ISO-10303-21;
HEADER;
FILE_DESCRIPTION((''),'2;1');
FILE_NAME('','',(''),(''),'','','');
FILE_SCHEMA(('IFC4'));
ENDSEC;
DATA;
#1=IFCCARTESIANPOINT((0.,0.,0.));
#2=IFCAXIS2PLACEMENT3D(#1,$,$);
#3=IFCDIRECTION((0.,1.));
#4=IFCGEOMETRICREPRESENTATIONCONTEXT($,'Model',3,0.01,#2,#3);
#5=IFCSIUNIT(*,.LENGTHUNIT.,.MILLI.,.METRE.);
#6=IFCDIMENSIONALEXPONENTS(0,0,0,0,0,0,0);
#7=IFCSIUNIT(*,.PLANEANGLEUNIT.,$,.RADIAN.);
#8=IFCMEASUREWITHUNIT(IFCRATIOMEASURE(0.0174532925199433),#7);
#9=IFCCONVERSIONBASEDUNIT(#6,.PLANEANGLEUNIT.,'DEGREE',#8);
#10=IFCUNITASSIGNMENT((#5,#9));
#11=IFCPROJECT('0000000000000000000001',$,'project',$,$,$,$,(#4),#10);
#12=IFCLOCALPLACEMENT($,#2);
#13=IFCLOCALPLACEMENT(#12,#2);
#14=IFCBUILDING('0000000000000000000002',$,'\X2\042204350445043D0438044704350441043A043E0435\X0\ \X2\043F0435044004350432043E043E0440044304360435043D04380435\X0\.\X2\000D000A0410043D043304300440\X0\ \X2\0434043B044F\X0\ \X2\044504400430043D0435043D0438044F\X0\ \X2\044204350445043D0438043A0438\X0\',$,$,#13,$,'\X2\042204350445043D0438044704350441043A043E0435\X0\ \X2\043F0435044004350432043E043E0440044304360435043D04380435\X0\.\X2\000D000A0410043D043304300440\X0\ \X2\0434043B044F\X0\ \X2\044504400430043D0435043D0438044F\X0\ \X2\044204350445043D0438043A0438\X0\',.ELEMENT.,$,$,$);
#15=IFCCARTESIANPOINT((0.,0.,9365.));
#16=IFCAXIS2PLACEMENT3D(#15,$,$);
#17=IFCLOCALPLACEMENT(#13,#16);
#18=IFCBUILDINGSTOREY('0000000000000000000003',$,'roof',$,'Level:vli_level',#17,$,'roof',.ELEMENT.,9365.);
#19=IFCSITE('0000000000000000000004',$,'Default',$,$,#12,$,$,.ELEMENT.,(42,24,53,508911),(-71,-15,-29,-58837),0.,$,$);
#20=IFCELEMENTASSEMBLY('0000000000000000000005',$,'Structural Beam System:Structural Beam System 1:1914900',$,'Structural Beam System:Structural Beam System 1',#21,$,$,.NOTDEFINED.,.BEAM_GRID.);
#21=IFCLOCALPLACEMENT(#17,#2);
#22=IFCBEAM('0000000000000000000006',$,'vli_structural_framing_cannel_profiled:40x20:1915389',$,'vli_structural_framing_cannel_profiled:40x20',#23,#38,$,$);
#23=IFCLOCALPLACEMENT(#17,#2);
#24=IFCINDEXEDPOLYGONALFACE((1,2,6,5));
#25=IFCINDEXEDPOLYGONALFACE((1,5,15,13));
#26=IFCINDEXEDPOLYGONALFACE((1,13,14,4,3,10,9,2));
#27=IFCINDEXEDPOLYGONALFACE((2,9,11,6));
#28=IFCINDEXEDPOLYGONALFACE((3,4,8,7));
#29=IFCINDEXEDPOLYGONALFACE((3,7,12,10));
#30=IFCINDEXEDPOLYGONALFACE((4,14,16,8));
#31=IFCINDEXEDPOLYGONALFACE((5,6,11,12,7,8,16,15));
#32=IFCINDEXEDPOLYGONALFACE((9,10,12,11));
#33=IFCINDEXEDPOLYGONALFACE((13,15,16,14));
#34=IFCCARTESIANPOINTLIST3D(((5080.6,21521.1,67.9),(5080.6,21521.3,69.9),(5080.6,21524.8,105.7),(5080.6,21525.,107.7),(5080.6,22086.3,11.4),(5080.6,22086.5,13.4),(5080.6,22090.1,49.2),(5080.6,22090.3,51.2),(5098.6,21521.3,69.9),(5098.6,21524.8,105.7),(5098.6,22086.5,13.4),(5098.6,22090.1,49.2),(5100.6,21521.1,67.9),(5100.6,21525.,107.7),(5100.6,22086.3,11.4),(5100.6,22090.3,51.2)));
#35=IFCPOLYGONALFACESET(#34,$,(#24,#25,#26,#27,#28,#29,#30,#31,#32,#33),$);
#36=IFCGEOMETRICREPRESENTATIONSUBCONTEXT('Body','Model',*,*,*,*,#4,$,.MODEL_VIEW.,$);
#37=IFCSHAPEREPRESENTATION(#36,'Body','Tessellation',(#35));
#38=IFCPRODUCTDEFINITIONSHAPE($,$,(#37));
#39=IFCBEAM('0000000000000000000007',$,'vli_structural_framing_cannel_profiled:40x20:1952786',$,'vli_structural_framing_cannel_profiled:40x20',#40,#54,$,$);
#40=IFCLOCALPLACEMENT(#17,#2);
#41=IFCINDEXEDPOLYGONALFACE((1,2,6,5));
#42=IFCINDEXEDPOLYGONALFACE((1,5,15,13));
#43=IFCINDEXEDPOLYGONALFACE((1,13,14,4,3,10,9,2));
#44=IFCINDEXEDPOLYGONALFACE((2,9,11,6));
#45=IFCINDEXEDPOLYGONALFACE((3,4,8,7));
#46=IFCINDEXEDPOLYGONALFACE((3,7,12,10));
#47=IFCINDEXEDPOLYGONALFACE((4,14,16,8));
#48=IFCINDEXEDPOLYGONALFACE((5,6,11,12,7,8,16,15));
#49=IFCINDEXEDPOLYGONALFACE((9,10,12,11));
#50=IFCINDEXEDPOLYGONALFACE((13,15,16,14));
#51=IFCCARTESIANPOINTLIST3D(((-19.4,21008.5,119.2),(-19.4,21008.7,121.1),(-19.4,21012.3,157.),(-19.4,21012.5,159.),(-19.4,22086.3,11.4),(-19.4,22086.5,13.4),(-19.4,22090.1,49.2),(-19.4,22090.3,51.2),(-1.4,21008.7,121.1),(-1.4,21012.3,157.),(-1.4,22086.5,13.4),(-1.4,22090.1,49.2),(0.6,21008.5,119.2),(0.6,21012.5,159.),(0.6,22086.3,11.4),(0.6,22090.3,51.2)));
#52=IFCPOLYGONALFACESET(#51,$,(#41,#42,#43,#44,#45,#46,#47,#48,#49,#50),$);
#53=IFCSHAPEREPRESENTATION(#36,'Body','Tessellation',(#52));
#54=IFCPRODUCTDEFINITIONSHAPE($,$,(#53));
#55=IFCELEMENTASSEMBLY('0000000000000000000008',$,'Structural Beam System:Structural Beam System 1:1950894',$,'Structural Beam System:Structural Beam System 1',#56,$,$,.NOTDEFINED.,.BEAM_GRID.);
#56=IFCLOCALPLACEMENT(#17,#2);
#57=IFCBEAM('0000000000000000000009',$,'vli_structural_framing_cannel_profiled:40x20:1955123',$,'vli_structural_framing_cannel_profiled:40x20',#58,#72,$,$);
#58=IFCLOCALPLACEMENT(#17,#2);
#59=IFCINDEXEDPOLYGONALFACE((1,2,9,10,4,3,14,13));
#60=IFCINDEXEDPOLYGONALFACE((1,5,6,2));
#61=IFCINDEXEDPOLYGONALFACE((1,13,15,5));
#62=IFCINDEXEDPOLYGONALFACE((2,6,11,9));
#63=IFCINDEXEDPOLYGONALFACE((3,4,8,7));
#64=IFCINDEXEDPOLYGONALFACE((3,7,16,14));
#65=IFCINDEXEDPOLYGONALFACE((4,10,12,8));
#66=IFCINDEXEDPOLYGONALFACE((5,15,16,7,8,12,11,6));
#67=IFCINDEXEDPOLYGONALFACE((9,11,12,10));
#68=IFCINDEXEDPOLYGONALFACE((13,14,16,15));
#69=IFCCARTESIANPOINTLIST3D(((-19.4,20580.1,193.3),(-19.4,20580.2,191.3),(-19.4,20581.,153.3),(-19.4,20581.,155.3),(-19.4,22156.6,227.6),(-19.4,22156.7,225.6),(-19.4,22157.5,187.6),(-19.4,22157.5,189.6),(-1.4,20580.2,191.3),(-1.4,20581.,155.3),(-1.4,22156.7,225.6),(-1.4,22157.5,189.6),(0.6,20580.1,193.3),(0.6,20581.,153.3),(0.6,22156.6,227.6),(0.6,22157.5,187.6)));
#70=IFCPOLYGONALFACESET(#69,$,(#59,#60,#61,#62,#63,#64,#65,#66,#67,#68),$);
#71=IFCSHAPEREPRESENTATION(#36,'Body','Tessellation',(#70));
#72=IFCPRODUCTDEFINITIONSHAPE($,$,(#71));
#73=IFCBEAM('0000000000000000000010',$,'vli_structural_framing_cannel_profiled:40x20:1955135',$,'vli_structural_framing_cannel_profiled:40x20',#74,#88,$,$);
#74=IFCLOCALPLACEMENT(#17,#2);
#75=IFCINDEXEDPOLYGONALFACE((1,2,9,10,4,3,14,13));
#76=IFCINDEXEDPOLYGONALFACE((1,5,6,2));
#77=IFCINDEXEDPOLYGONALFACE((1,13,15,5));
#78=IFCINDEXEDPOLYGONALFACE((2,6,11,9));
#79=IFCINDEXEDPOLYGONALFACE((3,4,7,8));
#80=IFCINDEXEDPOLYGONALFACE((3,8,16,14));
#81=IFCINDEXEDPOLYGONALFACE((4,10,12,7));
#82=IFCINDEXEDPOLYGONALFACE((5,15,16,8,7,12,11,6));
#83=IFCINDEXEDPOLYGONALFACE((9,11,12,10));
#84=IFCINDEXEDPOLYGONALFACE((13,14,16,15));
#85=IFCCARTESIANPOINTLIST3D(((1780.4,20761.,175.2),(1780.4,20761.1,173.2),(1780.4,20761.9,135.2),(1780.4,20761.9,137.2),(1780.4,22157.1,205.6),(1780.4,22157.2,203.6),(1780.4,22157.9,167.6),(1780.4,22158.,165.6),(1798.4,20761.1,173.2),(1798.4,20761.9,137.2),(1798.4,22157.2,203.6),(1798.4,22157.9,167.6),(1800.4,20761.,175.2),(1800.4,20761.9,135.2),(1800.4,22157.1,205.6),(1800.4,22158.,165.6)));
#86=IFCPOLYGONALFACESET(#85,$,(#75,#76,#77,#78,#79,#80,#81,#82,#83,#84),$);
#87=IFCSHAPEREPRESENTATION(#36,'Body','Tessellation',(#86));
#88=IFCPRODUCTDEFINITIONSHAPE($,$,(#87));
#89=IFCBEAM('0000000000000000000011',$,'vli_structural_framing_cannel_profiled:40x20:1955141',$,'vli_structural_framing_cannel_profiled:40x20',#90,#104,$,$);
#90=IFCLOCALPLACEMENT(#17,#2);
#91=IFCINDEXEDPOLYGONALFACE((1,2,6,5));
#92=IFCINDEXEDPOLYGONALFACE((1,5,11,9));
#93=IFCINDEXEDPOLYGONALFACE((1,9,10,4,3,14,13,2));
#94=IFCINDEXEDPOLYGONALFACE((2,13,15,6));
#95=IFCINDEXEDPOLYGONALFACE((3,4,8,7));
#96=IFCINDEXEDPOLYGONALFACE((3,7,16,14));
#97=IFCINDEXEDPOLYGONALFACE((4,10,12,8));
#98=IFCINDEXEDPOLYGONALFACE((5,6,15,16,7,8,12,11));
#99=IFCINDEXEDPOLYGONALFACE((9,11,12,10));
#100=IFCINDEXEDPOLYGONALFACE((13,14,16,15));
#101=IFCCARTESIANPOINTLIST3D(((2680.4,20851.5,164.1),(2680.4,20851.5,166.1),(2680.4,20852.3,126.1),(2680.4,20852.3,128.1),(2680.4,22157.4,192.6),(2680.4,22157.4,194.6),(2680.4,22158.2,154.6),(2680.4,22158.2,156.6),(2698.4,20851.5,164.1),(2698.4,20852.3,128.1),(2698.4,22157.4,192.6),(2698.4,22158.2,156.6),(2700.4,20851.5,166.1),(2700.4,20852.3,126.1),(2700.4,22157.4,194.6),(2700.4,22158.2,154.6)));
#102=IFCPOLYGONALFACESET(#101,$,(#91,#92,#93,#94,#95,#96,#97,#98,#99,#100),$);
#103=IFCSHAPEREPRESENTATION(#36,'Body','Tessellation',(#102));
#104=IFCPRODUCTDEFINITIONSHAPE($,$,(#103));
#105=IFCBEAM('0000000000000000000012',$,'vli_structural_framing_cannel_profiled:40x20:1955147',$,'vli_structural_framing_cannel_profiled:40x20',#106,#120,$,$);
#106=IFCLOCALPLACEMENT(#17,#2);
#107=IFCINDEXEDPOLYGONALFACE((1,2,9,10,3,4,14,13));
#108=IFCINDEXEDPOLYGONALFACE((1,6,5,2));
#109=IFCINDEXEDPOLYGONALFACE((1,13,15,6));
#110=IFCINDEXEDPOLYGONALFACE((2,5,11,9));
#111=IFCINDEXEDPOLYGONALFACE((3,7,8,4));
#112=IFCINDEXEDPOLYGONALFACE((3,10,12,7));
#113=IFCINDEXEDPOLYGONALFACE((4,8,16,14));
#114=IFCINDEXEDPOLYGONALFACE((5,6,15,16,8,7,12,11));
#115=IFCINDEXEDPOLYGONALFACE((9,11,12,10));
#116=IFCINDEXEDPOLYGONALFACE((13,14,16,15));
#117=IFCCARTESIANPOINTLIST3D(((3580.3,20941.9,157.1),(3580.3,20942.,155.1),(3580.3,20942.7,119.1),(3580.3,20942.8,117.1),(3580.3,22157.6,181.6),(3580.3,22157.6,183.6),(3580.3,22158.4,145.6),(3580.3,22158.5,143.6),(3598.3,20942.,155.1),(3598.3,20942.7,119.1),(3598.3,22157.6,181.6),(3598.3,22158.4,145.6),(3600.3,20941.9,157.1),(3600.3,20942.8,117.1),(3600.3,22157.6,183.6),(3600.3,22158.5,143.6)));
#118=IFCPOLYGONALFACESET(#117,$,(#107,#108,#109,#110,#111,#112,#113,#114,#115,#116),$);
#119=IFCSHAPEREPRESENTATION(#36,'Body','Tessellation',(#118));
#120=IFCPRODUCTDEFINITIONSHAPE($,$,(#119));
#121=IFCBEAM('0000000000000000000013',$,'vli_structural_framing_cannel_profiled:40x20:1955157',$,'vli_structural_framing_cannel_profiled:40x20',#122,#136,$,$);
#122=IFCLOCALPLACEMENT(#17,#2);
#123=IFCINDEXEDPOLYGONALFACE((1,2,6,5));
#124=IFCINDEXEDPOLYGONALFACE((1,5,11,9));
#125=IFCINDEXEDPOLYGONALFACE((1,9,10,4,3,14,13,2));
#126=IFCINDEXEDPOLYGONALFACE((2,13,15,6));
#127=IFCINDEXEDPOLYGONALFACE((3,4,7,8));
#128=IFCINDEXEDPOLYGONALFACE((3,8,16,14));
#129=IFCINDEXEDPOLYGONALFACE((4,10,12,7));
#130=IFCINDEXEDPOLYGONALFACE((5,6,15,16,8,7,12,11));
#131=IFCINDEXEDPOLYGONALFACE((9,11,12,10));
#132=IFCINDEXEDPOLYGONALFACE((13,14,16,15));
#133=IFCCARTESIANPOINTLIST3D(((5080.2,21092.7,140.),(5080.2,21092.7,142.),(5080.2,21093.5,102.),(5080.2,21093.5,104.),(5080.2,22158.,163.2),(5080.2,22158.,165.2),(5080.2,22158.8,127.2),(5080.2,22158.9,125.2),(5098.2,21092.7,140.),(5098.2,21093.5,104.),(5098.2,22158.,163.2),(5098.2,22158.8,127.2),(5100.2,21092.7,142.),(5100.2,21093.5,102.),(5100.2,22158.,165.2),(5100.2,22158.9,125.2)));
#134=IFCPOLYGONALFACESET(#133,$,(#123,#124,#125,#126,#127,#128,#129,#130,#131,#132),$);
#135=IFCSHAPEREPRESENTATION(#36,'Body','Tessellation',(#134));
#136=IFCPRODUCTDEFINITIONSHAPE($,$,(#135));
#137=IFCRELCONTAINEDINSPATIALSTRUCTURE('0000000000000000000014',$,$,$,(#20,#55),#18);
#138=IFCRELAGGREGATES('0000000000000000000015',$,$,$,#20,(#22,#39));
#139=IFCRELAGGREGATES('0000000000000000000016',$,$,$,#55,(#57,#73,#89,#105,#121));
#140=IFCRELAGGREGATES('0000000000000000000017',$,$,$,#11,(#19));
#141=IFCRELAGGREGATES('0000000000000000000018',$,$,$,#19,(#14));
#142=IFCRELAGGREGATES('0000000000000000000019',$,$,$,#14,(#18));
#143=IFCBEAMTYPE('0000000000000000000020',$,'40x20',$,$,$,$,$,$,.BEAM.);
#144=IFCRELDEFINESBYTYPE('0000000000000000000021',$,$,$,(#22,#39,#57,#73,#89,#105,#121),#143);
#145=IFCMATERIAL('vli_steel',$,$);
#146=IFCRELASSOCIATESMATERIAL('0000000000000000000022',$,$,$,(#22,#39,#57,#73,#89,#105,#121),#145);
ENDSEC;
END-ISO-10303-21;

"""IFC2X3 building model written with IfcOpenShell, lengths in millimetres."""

from ifc_helpers import new_model, entity, si_unit, converted_unit, direction, frame, origin, place, context, subcontext, project, spatial, polyline, outline, extrude, material, type_object, element, aggregate, save


model = new_model("IFC2X3")

# Units and contexts
model_context = context("Model", 3, precision=0.01, world=origin(), true_north=direction((0.0, 1.0)))
body_context = subcontext(model_context, "Body", "Model", "MODEL_VIEW")
ifc_project = project(units=[si_unit("LENGTHUNIT", "METRE", prefix="MILLI"), converted_unit("PLANEANGLEUNIT", "DEGREE", entity("IfcRatioMeasure", 0.0174532925199433), si_unit("PLANEANGLEUNIT", "RADIAN"), dimensions=[0, 0, 0, 0, 0, 0, 0])], contexts=[model_context])

# Site, building, storey
site_placement = place(None, origin())
site = spatial("IfcSite", under=ifc_project, at=site_placement, Name="Default", CompositionType="ELEMENT", RefLatitude=(42, 24, 53, 508911), RefLongitude=(-71, -15, -29, -58837), RefElevation=0.0)
building_placement = place(site_placement, origin())
building = spatial("IfcBuilding", under=site, at=building_placement, Name="Техническое перевооружение.\r\nАнгар для хранения техники", LongName="Техническое перевооружение.\r\nАнгар для хранения техники", CompositionType="ELEMENT")
storey_placement = place(building_placement, frame((0.0, 0.0, 9365.0)))
storey = spatial("IfcBuildingStorey", under=building, at=storey_placement, Name="roof", ObjectType="Level:vli_level", LongName="roof", CompositionType="ELEMENT", Elevation=9365.0)

# Element assemblies, beams
assembly_1_placement = place(storey_placement, origin())
assembly_1 = element("IfcElementAssembly", 1, at=assembly_1_placement, inside=storey, Name="Structural Beam System:Structural Beam System 1:1914900", ObjectType="Structural Beam System:Structural Beam System 1", AssemblyPlace="NOTDEFINED", PredefinedType="BEAM_GRID")
ifc_material = material(Name="vli_steel")
beam_type = type_object("IfcBeamType", Name="40x20", PredefinedType="BEAM")
beam_1_placement = place(assembly_1_placement, frame((5100.0, 22090.8, 10.9), z_axis=(0.0, 0.099504, 0.995037), x_axis=(0.0, -0.995037, 0.099504)))
beam_1 = element("IfcBeam", 2, at=beam_1_placement, type_object=beam_type, material=ifc_material, Name="vli_structural_framing_cannel_profiled:40x20:1915389", ObjectType="vli_structural_framing_cannel_profiled:40x20", context=body_context, shape_type="SweptSolid", body=[
    extrude(outline(polyline([(-20.0, -9.5), (-18.0, -9.5), (-18.0, 8.5), (18.0, 8.5), (18.0, -9.5), (20.0, -9.5), (20.0, 10.5), (-20.0, 10.5), (-20.0, -9.5)])), frame((4.6, -9.9, 20.0), z_axis=(1.0, 0.0, 0.0), x_axis=(0.0, 0.0, -1.0)), (0.0, 0.0, 1.0), 568.0),
])
beam_2_placement = place(assembly_1_placement, frame((0.0, 22090.8, 10.9), z_axis=(0.0, 0.099504, 0.995037), x_axis=(0.0, -0.995037, 0.099504)))
beam_2 = element("IfcBeam", 3, at=beam_2_placement, type_object=beam_type, material=ifc_material, Name="vli_structural_framing_cannel_profiled:40x20:1952786", ObjectType="vli_structural_framing_cannel_profiled:40x20", context=body_context, shape_type="SweptSolid", body=[
    extrude(outline(polyline([(-20.0, -9.5), (-18.0, -9.5), (-18.0, 8.5), (18.0, 8.5), (18.0, -9.5), (20.0, -9.5), (20.0, 10.5), (-20.0, 10.5), (-20.0, -9.5)])), frame((4.6, -9.9, 20.0), z_axis=(1.0, 0.0, 0.0), x_axis=(0.0, 0.0, -1.0)), (0.0, 0.0, 1.0), 1083.2),
])
aggregate(assembly_1, [beam_1, beam_2])
assembly_2_placement = place(storey_placement, origin())
assembly_2 = element("IfcElementAssembly", 4, at=assembly_2_placement, inside=storey, Name="Structural Beam System:Structural Beam System 1:1950894", ObjectType="Structural Beam System:Structural Beam System 1", AssemblyPlace="NOTDEFINED", PredefinedType="BEAM_GRID")
beam_3_placement = place(assembly_2_placement, frame((0.0, 22158.1, 227.6), z_axis=(0.0, -0.021793, 0.999763), x_axis=(0.0, -0.999763, -0.021793)))
beam_3 = element("IfcBeam", 5, at=beam_3_placement, type_object=beam_type, material=ifc_material, Name="vli_structural_framing_cannel_profiled:40x20:1955123", ObjectType="vli_structural_framing_cannel_profiled:40x20", context=body_context, shape_type="SweptSolid", body=[
    extrude(outline(polyline([(-20.0, -9.5), (-18.0, -9.5), (-18.0, 8.5), (18.0, 8.5), (18.0, -9.5), (20.0, -9.5), (20.0, 10.5), (-20.0, 10.5), (-20.0, -9.5)])), frame((1.5, -9.9, -20.0), z_axis=(1.0, 0.0, 0.0), x_axis=(0.0, 0.0, -1.0)), (0.0, 0.0, 1.0), 1576.9),
])
beam_4_placement = place(assembly_2_placement, frame((1799.8, 22158.6, 205.6), z_axis=(0.0, -0.021793, 0.999763), x_axis=(0.0, -0.999763, -0.021793)))
beam_4 = element("IfcBeam", 6, at=beam_4_placement, type_object=beam_type, material=ifc_material, Name="vli_structural_framing_cannel_profiled:40x20:1955135", ObjectType="vli_structural_framing_cannel_profiled:40x20", context=body_context, shape_type="SweptSolid", body=[
    extrude(outline(polyline([(-20.0, -9.5), (-18.0, -9.5), (-18.0, 8.5), (18.0, 8.5), (18.0, -9.5), (20.0, -9.5), (20.0, 10.5), (-20.0, 10.5), (-20.0, -9.5)])), frame((1.5, -9.9, -20.0), z_axis=(1.0, 0.0, 0.0), x_axis=(0.0, 0.0, -1.0)), (0.0, 0.0, 1.0), 1396.4),
])
beam_5_placement = place(assembly_2_placement, frame((2699.8, 22158.8, 194.6), z_axis=(0.0, -0.021793, 0.999763), x_axis=(0.0, -0.999763, -0.021793)))
beam_5 = element("IfcBeam", 7, at=beam_5_placement, type_object=beam_type, material=ifc_material, Name="vli_structural_framing_cannel_profiled:40x20:1955141", ObjectType="vli_structural_framing_cannel_profiled:40x20", context=body_context, shape_type="SweptSolid", body=[
    extrude(outline(polyline([(-20.0, -9.5), (-18.0, -9.5), (-18.0, 8.5), (18.0, 8.5), (18.0, -9.5), (20.0, -9.5), (20.0, 10.5), (-20.0, 10.5), (-20.0, -9.5)])), frame((1.5, -9.9, -20.0), z_axis=(1.0, 0.0, 0.0), x_axis=(0.0, 0.0, -1.0)), (0.0, 0.0, 1.0), 1306.2),
])
beam_6_placement = place(assembly_2_placement, frame((3599.7, 22159.1, 183.6), z_axis=(0.0, -0.021793, 0.999763), x_axis=(0.0, -0.999763, -0.021793)))
beam_6 = element("IfcBeam", 8, at=beam_6_placement, type_object=beam_type, material=ifc_material, Name="vli_structural_framing_cannel_profiled:40x20:1955147", ObjectType="vli_structural_framing_cannel_profiled:40x20", context=body_context, shape_type="SweptSolid", body=[
    extrude(outline(polyline([(-20.0, -9.5), (-18.0, -9.5), (-18.0, 8.5), (18.0, 8.5), (18.0, -9.5), (20.0, -9.5), (20.0, 10.5), (-20.0, 10.5), (-20.0, -9.5)])), frame((1.5, -9.9, -20.0), z_axis=(1.0, 0.0, 0.0), x_axis=(0.0, 0.0, -1.0)), (0.0, 0.0, 1.0), 1216.0),
])
beam_7_placement = place(assembly_2_placement, frame((5099.6, 22159.5, 165.3), z_axis=(0.0, -0.021793, 0.999763), x_axis=(0.0, -0.999763, -0.021793)))
beam_7 = element("IfcBeam", 9, at=beam_7_placement, type_object=beam_type, material=ifc_material, Name="vli_structural_framing_cannel_profiled:40x20:1955157", ObjectType="vli_structural_framing_cannel_profiled:40x20", context=body_context, shape_type="SweptSolid", body=[
    extrude(outline(polyline([(-20.0, -9.5), (-18.0, -9.5), (-18.0, 8.5), (18.0, 8.5), (18.0, -9.5), (20.0, -9.5), (20.0, 10.5), (-20.0, 10.5), (-20.0, -9.5)])), frame((1.5, -9.9, -20.0), z_axis=(1.0, 0.0, 0.0), x_axis=(0.0, 0.0, -1.0)), (0.0, 0.0, 1.0), 1065.6),
])
aggregate(assembly_2, [beam_3, beam_4, beam_5, beam_6, beam_7])

save(model, "model.ifc")
